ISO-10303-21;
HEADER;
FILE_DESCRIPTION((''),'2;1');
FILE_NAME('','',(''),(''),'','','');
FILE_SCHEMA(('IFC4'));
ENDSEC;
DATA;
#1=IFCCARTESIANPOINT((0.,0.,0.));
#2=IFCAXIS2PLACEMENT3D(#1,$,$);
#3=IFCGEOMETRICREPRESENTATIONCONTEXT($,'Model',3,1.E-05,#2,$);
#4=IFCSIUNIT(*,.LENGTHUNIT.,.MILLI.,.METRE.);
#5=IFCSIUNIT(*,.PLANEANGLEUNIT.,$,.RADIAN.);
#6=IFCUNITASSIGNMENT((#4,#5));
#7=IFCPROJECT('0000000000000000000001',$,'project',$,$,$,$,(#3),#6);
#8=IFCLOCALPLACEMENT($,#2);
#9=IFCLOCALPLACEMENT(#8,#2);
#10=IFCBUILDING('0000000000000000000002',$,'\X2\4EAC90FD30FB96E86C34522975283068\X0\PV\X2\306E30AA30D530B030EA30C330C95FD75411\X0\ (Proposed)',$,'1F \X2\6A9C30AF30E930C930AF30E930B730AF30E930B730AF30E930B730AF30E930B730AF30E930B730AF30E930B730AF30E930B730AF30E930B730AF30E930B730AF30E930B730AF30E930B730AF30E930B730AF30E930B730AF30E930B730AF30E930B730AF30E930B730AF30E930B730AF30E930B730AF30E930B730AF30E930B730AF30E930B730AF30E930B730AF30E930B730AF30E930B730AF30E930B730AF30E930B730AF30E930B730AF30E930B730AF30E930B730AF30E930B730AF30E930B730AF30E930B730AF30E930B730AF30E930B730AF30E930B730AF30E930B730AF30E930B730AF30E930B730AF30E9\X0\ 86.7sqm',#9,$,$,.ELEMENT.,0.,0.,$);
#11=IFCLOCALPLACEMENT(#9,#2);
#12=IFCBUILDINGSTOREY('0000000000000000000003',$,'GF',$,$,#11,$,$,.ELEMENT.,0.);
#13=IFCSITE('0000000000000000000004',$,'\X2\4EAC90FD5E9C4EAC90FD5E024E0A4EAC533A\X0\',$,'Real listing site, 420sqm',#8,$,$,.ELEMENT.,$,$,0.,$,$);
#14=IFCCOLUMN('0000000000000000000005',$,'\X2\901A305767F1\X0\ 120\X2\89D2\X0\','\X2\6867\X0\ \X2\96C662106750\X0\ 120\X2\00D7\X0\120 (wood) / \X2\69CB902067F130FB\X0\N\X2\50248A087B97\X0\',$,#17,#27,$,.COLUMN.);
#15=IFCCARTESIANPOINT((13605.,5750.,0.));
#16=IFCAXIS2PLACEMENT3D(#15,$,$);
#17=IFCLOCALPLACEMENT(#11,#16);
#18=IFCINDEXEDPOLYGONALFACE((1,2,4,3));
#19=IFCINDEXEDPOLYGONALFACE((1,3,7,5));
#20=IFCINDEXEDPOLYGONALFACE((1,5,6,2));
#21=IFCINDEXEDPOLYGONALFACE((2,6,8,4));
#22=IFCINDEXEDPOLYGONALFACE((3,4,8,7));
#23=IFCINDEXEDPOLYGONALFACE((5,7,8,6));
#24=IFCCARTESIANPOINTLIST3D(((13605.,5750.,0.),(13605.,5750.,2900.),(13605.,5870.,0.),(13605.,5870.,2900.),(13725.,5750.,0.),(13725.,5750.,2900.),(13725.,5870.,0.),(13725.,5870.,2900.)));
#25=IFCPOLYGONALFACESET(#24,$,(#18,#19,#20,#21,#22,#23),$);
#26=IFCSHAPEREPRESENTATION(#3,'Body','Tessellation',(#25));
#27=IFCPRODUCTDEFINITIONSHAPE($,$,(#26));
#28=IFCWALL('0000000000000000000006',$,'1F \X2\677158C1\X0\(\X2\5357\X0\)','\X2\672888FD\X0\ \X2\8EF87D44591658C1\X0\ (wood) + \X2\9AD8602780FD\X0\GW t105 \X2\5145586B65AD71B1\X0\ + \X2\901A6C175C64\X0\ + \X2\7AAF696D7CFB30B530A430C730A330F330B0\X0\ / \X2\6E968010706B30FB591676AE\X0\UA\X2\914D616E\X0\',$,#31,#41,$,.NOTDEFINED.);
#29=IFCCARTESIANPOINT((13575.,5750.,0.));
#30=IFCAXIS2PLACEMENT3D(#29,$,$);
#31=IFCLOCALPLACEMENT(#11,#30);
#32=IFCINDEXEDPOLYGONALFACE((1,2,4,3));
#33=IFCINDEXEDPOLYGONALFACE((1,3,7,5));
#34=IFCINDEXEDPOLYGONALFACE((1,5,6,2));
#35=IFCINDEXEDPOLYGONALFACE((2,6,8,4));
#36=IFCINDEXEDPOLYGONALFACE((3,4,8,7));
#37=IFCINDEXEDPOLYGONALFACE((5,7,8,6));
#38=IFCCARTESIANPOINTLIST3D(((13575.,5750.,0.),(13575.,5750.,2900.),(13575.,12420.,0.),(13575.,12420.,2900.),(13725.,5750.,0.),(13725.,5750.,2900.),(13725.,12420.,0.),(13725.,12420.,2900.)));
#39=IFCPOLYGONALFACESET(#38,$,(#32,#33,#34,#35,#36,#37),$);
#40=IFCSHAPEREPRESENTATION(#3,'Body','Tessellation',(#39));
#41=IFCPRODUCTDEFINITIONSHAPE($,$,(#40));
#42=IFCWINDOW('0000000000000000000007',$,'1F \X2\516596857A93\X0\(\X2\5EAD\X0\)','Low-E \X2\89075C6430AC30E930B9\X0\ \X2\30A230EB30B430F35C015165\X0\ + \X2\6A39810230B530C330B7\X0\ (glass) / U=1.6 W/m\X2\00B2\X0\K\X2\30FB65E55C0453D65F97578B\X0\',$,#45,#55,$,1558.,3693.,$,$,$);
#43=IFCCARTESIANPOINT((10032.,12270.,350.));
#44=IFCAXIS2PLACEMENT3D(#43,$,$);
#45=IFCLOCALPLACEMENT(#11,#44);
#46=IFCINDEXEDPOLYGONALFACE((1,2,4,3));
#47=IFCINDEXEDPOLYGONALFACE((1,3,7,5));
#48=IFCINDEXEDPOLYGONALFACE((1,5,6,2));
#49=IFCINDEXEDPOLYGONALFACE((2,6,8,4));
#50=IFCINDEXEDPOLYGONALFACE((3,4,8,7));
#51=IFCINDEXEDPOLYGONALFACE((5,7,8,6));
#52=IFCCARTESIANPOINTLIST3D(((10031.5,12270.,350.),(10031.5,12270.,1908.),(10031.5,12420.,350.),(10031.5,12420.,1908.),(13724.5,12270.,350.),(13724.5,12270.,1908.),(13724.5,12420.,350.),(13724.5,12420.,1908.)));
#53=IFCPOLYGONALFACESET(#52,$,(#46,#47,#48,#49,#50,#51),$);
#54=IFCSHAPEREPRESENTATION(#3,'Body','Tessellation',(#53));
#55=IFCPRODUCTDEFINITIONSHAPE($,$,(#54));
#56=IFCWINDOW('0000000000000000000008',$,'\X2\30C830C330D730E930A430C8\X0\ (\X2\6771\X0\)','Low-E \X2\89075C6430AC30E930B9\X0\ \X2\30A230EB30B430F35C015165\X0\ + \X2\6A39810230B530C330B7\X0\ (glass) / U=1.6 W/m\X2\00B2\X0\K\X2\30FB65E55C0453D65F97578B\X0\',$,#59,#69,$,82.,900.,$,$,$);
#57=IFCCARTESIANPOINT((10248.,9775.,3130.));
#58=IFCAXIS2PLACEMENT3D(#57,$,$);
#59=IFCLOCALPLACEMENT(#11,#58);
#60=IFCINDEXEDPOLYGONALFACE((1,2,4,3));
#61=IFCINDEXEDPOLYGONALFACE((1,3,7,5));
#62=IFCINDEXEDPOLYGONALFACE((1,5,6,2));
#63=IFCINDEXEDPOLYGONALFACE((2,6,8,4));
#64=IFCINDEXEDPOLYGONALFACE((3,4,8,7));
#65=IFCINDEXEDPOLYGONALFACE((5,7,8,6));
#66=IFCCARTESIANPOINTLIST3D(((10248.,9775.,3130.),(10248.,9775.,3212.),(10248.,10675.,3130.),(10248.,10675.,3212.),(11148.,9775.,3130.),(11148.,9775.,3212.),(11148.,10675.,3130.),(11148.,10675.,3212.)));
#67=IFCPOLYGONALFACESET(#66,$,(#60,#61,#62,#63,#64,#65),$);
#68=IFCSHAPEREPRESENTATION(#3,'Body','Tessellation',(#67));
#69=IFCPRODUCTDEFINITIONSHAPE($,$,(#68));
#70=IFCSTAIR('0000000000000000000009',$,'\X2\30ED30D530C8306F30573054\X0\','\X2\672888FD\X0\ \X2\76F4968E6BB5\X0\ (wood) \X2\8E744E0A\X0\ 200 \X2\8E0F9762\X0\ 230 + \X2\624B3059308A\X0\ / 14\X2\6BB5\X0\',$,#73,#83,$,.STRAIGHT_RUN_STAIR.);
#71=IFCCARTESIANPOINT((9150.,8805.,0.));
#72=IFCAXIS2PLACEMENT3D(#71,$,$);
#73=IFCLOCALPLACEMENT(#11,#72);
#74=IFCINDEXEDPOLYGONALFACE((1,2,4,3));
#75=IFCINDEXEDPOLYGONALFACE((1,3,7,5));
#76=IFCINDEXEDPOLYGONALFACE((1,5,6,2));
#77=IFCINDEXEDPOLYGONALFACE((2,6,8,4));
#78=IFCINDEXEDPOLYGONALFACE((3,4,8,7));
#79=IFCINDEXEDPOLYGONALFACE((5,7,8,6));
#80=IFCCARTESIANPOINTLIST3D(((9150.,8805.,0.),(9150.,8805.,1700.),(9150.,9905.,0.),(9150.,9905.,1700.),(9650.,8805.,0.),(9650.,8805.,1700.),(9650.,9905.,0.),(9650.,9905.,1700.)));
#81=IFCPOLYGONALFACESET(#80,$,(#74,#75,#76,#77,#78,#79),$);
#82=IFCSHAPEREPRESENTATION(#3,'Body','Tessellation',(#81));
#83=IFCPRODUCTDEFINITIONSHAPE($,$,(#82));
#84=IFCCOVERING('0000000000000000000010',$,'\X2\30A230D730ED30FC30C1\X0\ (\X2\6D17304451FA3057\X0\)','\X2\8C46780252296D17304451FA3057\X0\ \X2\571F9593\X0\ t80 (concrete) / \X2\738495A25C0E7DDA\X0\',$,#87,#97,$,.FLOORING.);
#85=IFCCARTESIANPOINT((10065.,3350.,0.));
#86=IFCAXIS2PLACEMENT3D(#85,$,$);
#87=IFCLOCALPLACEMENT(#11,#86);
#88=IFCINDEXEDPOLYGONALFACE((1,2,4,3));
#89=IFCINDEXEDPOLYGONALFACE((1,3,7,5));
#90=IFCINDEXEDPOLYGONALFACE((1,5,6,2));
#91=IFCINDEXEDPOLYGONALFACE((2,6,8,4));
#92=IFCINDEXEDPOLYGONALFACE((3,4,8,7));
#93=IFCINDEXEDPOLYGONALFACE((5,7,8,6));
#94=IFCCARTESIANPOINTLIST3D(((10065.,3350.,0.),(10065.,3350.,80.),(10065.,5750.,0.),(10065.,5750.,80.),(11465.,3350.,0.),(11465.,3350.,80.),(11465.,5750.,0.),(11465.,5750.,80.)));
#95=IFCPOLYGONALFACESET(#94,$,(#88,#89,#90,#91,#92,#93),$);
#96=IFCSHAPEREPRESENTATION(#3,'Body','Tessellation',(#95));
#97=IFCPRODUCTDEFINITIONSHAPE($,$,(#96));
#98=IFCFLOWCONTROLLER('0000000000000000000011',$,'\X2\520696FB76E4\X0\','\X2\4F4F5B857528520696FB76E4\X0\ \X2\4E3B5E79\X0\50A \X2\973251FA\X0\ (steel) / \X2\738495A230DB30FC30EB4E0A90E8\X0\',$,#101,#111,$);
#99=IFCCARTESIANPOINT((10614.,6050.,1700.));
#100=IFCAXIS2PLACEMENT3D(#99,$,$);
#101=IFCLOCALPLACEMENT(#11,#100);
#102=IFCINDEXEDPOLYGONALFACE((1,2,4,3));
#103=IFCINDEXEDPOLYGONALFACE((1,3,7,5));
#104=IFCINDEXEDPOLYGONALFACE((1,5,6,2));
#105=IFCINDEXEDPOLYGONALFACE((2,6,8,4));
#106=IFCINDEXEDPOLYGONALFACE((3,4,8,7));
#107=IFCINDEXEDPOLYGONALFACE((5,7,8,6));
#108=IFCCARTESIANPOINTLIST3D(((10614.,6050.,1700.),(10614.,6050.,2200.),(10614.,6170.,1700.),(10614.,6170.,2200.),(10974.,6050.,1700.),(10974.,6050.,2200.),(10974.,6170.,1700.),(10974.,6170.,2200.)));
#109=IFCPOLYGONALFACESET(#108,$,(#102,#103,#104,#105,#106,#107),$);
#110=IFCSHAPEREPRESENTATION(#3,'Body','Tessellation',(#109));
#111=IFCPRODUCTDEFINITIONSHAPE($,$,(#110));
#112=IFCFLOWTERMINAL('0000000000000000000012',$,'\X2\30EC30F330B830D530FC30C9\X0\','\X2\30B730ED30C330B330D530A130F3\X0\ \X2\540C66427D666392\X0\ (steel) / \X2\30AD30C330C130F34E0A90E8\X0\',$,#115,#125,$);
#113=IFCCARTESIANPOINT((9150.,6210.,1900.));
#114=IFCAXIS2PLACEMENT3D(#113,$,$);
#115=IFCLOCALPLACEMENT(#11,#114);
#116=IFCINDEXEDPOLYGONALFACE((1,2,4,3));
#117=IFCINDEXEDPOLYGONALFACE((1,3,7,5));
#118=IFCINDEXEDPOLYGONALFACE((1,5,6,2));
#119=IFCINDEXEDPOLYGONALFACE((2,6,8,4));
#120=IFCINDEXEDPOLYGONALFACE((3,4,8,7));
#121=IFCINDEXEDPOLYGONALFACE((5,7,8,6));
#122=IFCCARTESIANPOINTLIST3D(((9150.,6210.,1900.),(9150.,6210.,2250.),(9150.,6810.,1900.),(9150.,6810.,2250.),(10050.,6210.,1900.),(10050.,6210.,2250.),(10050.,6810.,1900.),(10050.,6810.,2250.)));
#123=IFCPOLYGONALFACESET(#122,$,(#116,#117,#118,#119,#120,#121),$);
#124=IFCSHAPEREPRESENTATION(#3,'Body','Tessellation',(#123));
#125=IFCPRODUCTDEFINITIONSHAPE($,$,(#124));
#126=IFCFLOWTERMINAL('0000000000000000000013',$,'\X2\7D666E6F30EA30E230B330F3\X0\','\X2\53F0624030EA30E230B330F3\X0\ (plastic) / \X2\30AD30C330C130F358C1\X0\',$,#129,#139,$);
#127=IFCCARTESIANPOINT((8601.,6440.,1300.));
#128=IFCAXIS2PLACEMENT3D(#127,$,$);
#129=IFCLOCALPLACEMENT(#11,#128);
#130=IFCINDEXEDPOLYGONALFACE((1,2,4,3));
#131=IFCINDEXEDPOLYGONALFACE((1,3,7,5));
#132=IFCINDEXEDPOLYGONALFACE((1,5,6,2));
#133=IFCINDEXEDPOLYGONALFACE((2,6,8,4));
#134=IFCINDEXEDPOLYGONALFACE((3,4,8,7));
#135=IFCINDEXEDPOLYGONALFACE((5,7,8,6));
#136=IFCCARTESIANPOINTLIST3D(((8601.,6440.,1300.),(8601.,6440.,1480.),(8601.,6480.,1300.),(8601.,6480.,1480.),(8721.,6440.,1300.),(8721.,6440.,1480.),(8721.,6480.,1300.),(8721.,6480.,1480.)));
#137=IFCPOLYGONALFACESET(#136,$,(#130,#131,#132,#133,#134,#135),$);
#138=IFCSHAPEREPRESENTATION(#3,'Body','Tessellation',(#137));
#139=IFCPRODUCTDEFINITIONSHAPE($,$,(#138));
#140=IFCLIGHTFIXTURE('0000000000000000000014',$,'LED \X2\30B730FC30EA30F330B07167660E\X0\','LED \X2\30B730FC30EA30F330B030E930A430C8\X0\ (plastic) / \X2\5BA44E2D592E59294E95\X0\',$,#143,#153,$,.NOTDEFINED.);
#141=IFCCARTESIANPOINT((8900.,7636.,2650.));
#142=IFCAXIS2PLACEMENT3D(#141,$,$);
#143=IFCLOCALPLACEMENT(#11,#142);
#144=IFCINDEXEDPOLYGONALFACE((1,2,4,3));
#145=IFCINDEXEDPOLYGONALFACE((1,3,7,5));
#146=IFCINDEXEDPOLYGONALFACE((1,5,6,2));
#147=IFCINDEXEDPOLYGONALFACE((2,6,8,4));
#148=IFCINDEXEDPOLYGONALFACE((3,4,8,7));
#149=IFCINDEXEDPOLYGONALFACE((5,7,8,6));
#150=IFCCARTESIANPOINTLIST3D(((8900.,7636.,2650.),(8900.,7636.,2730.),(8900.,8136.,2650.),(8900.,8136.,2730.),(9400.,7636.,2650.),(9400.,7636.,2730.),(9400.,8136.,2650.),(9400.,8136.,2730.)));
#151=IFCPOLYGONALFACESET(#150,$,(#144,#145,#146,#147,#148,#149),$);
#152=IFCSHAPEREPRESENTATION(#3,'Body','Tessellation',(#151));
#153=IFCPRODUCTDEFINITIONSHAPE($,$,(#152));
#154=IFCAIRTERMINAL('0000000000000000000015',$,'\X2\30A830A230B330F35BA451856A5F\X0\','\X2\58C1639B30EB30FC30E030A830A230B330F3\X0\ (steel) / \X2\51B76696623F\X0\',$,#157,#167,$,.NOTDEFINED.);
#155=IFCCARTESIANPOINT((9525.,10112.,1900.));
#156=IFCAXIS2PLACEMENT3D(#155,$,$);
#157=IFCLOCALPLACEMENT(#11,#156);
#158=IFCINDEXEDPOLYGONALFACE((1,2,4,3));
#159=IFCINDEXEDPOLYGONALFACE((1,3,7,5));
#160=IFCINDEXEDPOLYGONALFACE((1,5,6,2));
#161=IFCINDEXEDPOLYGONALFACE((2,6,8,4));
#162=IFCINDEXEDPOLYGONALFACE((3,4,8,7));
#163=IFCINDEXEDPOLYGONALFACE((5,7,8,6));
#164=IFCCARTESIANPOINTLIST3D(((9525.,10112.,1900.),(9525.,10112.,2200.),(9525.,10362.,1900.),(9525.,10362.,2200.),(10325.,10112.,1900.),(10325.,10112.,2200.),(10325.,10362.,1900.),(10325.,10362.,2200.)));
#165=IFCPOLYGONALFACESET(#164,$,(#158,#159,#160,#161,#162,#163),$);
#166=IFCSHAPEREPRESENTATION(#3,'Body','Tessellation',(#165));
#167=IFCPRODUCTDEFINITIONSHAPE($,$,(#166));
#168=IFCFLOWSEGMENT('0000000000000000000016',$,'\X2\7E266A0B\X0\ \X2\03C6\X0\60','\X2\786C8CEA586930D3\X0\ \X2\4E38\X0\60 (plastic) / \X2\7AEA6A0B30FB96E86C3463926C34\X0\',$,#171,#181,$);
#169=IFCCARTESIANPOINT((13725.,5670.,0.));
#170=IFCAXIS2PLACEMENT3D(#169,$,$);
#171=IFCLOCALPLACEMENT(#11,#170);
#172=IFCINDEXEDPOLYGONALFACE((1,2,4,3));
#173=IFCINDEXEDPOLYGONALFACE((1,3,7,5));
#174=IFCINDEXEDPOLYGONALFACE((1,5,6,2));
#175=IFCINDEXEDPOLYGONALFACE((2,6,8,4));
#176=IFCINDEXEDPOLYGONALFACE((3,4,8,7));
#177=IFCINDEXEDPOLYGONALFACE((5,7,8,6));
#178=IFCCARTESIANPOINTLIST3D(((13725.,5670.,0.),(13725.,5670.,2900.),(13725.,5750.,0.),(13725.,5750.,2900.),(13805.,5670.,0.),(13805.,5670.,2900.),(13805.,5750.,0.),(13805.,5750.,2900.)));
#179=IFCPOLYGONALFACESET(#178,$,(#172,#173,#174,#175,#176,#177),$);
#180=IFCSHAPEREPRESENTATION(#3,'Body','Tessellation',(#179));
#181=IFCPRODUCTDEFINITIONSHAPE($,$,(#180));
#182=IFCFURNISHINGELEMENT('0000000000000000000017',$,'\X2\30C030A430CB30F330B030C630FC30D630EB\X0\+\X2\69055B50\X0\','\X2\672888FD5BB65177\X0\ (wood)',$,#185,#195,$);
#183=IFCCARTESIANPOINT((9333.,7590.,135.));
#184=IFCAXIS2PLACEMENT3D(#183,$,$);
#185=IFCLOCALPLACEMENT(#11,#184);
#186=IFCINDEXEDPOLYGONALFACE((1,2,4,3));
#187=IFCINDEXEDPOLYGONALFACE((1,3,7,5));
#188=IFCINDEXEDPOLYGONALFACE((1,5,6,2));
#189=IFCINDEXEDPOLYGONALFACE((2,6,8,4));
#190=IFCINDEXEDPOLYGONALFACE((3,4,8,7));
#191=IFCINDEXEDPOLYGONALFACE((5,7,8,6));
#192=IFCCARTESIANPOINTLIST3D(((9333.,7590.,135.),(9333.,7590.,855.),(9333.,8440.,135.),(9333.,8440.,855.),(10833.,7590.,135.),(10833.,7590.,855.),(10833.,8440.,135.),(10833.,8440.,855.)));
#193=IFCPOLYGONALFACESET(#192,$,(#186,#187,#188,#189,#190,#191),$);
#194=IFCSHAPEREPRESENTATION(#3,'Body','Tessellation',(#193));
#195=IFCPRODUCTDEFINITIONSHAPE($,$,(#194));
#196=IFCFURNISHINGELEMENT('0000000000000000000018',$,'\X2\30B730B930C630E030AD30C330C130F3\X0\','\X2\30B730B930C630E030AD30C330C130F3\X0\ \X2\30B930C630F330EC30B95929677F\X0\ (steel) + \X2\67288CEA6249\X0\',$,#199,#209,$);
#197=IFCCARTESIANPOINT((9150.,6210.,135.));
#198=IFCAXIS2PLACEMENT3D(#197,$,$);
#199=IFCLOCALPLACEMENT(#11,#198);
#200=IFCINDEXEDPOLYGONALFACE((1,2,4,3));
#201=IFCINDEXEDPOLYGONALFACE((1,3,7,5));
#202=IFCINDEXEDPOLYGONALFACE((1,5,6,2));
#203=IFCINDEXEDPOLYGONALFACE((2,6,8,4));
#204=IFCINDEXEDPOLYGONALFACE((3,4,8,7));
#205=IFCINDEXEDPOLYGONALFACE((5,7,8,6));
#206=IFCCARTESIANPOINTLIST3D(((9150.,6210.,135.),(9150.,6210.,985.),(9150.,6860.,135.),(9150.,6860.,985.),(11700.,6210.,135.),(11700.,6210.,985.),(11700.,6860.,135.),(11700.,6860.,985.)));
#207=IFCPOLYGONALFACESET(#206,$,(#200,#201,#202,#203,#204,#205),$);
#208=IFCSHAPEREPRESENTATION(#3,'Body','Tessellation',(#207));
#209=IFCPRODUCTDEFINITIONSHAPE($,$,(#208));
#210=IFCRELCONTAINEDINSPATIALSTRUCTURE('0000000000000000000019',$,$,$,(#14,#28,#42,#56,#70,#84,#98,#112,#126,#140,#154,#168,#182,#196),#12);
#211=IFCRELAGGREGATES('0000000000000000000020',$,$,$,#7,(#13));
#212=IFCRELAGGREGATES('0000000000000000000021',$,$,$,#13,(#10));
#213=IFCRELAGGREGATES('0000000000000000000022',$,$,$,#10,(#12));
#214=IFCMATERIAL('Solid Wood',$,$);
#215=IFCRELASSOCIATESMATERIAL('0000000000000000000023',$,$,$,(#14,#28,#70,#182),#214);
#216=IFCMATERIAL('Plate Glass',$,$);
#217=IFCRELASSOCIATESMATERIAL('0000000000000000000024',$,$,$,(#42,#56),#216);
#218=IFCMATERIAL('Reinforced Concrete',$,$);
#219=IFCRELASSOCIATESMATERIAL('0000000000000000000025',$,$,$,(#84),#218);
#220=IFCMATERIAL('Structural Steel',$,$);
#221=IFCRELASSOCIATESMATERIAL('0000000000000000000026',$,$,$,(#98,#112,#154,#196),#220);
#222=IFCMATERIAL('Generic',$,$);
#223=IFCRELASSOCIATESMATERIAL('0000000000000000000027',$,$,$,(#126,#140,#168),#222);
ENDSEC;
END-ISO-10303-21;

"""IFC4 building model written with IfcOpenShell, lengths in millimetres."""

from ifc_helpers import new_model, si_unit, frame, frame_2d, origin, place, context, project, spatial, rectangle, extrude, material, element, fill, save


model = new_model("IFC4")

# Units and contexts
model_context = context("Model", 3, precision=1e-05, world=origin())
ifc_project = project(units=[si_unit("LENGTHUNIT", "METRE", prefix="MILLI"), si_unit("PLANEANGLEUNIT", "RADIAN")], contexts=[model_context])

# Site, building, storey
site_placement = place(None, origin())
site = spatial("IfcSite", under=ifc_project, at=site_placement, Name="京都府京都市上京区", ObjectType="Real listing site, 420sqm", CompositionType="ELEMENT", RefElevation=0.0)
building_placement = place(site_placement, origin())
building = spatial("IfcBuilding", under=site, at=building_placement, Name="京都・雨水利用とPVのオフグリッド志向 (Proposed)", ObjectType="1F 檜クラドクラシクラシクラシクラシクラシクラシクラシクラシクラシクラシクラシクラシクラシクラシクラシクラシクラシクラシクラシクラシクラシクラシクラシクラシクラシクラシクラシクラシクラシクラシクラシクラシクラシクラシクラシクラシクラシクラシクラ 86.7sqm", CompositionType="ELEMENT", ElevationOfRefHeight=0.0, ElevationOfTerrain=0.0)
storey_placement = place(building_placement, origin())
storey = spatial("IfcBuildingStorey", under=building, at=storey_placement, Name="GF", CompositionType="ELEMENT", Elevation=0.0)

# Column
ifc_material_1 = material(Name="Solid Wood")
column_1_placement = place(storey_placement, frame((13605.0, 5750.0, 0.0)))
element("IfcColumn", 1, at=column_1_placement, inside=storey, material=ifc_material_1, Name="通し柱 120角", Description="桧 集成材 120×120 (wood) / 構造柱・N値計算", PredefinedType="COLUMN", context=model_context, shape_type="SweptSolid", body=[
    extrude(rectangle(XDim=120.0, YDim=120.0, at=frame_2d((60.0, 60.0))), frame((13605.0, 5750.0, 0.0)), (0.0, 0.0, 1.0), 2900.0),
])

# Wall, opening, window
wall_1_placement = place(storey_placement, frame((13575.0, 5750.0, 0.0)))
wall_1 = element("IfcWall", 2, at=wall_1_placement, inside=storey, material=ifc_material_1, Name="1F 東壁(南)", Description="木製 軸組外壁 (wood) + 高性能GW t105 充填断熱 + 通気層 + 窯業系サイディング / 準耐火・外皮UA配慮", PredefinedType="NOTDEFINED", context=model_context, shape_type="SweptSolid", body=[
    extrude(rectangle(XDim=150.0, YDim=6670.0, at=frame_2d((75.0, 3335.0))), frame((13575.0, 5750.0, 0.0)), (0.0, 0.0, 1.0), 2900.0),
])
opening_1_placement = place(storey_placement, frame((10032.0, 12270.0, 350.0)))
opening_1 = element("IfcOpeningElement", 3, at=opening_1_placement, cuts=wall_1, PredefinedType="NOTDEFINED", context=model_context, shape_type="SweptSolid", body=[
    extrude(rectangle(XDim=3693.0, YDim=150.0, at=frame_2d((1846.0, 75.0))), frame((10032.0, 12270.0, 350.0)), (0.0, 0.0, 1.0), 1558.0),
])
ifc_material_2 = material(Name="Plate Glass")
window_1_placement = place(storey_placement, frame((10032.0, 12270.0, 350.0)))
window_1 = element("IfcWindow", 4, at=window_1_placement, inside=storey, material=ifc_material_2, Name="1F 入隅窓(庭)", Description="Low-E 複層ガラス アルゴン封入 + 樹脂サッシ (glass) / U=1.6 W/m²K・日射取得型", OverallHeight=1558.0, OverallWidth=3693.0, context=model_context, shape_type="SweptSolid", body=[
    extrude(rectangle(XDim=3693.0, YDim=150.0, at=frame_2d((1846.0, 75.0))), frame((10032.0, 12270.0, 350.0)), (0.0, 0.0, 1.0), 1558.0),
])
fill(opening_1, window_1)

# Window
window_2_placement = place(storey_placement, frame((10248.0, 9775.0, 3130.0)))
element("IfcWindow", 5, at=window_2_placement, inside=storey, material=ifc_material_2, Name="トップライト (東)", Description="Low-E 複層ガラス アルゴン封入 + 樹脂サッシ (glass) / U=1.6 W/m²K・日射取得型", OverallHeight=82.0, OverallWidth=900.0, context=model_context, shape_type="SweptSolid", body=[
    extrude(rectangle(XDim=900.0, YDim=900.0, at=frame_2d((450.0, 450.0))), frame((10248.0, 9775.0, 3130.0)), (0.0, 0.0, 1.0), 82.0),
])

# Stair
stair_placement = place(storey_placement, frame((9150.0, 8805.0, 0.0)))
element("IfcStair", 6, at=stair_placement, inside=storey, material=ifc_material_1, Name="ロフトはしご", Description="木製 直階段 (wood) 蹴上 200 踏面 230 + 手すり / 14段", PredefinedType="STRAIGHT_RUN_STAIR", context=model_context, shape_type="SweptSolid", body=[
    extrude(rectangle(XDim=500.0, YDim=1100.0, at=frame_2d((250.0, 550.0))), frame((9150.0, 8805.0, 0.0)), (0.0, 0.0, 1.0), 1700.0),
])

# Covering
ifc_material_3 = material(Name="Reinforced Concrete")
covering_placement = place(storey_placement, frame((10065.0, 3350.0, 0.0)))
element("IfcCovering", 7, at=covering_placement, inside=storey, material=ifc_material_3, Name="アプローチ (洗い出し)", Description="豆砂利洗い出し 土間 t80 (concrete) / 玄関導線", PredefinedType="FLOORING", context=model_context, shape_type="SweptSolid", body=[
    extrude(rectangle(XDim=1400.0, YDim=2400.0, at=frame_2d((700.0, 1200.0))), frame((10065.0, 3350.0, 0.0)), (0.0, 0.0, 1.0), 80.0),
])

# Flow controller
ifc_material_4 = material(Name="Structural Steel")
flow_controller_placement = place(storey_placement, frame((10614.0, 6050.0, 1700.0)))
element("IfcFlowController", 8, at=flow_controller_placement, inside=storey, material=ifc_material_4, Name="分電盤", Description="住宅用分電盤 主幹50A 露出 (steel) / 玄関ホール上部", context=model_context, shape_type="SweptSolid", body=[
    extrude(rectangle(XDim=360.0, YDim=120.0, at=frame_2d((180.0, 60.0))), frame((10614.0, 6050.0, 1700.0)), (0.0, 0.0, 1.0), 500.0),
])

# Flow terminals
flow_terminal_1_placement = place(storey_placement, frame((9150.0, 6210.0, 1900.0)))
element("IfcFlowTerminal", 9, at=flow_terminal_1_placement, inside=storey, material=ifc_material_4, Name="レンジフード", Description="シロッコファン 同時給排 (steel) / キッチン上部", context=model_context, shape_type="SweptSolid", body=[
    extrude(rectangle(XDim=900.0, YDim=600.0, at=frame_2d((450.0, 300.0))), frame((9150.0, 6210.0, 1900.0)), (0.0, 0.0, 1.0), 350.0),
])
ifc_material_5 = material(Name="Generic")
flow_terminal_2_placement = place(storey_placement, frame((8601.0, 6440.0, 1300.0)))
element("IfcFlowTerminal", 10, at=flow_terminal_2_placement, inside=storey, material=ifc_material_5, Name="給湯リモコン", Description="台所リモコン (plastic) / キッチン壁", context=model_context, shape_type="SweptSolid", body=[
    extrude(rectangle(XDim=120.0, YDim=40.0, at=frame_2d((60.0, 20.0))), frame((8601.0, 6440.0, 1300.0)), (0.0, 0.0, 1.0), 180.0),
])

# Light fixture
light_fixture_placement = place(storey_placement, frame((8900.0, 7636.0, 2650.0)))
element("IfcLightFixture", 11, at=light_fixture_placement, inside=storey, material=ifc_material_5, Name="LED シーリング照明", Description="LED シーリングライト (plastic) / 室中央天井", PredefinedType="NOTDEFINED", context=model_context, shape_type="SweptSolid", body=[
    extrude(rectangle(XDim=500.0, YDim=500.0, at=frame_2d((250.0, 250.0))), frame((8900.0, 7636.0, 2650.0)), (0.0, 0.0, 1.0), 80.0),
])

# Air terminal
air_terminal_placement = place(storey_placement, frame((9525.0, 10112.0, 1900.0)))
element("IfcAirTerminal", 12, at=air_terminal_placement, inside=storey, material=ifc_material_4, Name="エアコン室内機", Description="壁掛ルームエアコン (steel) / 冷暖房", PredefinedType="NOTDEFINED", context=model_context, shape_type="SweptSolid", body=[
    extrude(rectangle(XDim=800.0, YDim=250.0, at=frame_2d((400.0, 125.0))), frame((9525.0, 10112.0, 1900.0)), (0.0, 0.0, 1.0), 300.0),
])

# Flow segment
flow_segment_placement = place(storey_placement, frame((13725.0, 5670.0, 0.0)))
element("IfcFlowSegment", 13, at=flow_segment_placement, inside=storey, material=ifc_material_5, Name="縦樋 φ60", Description="硬質塩ビ 丸60 (plastic) / 竪樋・雨水排水", context=model_context, shape_type="SweptSolid", body=[
    extrude(rectangle(XDim=80.0, YDim=80.0, at=frame_2d((40.0, 40.0))), frame((13725.0, 5670.0, 0.0)), (0.0, 0.0, 1.0), 2900.0),
])

# Furnishing elements
furnishing_1_placement = place(storey_placement, frame((9333.0, 7590.0, 135.0)))
element("IfcFurnishingElement", 14, at=furnishing_1_placement, inside=storey, material=ifc_material_1, Name="ダイニングテーブル+椅子", Description="木製家具 (wood)", context=model_context, shape_type="SweptSolid", body=[
    extrude(rectangle(XDim=1500.0, YDim=850.0, at=frame_2d((750.0, 425.0))), frame((9333.0, 7590.0, 135.0)), (0.0, 0.0, 1.0), 720.0),
])
furnishing_2_placement = place(storey_placement, frame((9150.0, 6210.0, 135.0)))
element("IfcFurnishingElement", 15, at=furnishing_2_placement, inside=storey, material=ifc_material_4, Name="システムキッチン", Description="システムキッチン ステンレス天板 (steel) + 木質扉", context=model_context, shape_type="SweptSolid", body=[
    extrude(rectangle(XDim=2550.0, YDim=650.0, at=frame_2d((1275.0, 325.0))), frame((9150.0, 6210.0, 135.0)), (0.0, 0.0, 1.0), 850.0),
])

save(model, "model.ifc")
